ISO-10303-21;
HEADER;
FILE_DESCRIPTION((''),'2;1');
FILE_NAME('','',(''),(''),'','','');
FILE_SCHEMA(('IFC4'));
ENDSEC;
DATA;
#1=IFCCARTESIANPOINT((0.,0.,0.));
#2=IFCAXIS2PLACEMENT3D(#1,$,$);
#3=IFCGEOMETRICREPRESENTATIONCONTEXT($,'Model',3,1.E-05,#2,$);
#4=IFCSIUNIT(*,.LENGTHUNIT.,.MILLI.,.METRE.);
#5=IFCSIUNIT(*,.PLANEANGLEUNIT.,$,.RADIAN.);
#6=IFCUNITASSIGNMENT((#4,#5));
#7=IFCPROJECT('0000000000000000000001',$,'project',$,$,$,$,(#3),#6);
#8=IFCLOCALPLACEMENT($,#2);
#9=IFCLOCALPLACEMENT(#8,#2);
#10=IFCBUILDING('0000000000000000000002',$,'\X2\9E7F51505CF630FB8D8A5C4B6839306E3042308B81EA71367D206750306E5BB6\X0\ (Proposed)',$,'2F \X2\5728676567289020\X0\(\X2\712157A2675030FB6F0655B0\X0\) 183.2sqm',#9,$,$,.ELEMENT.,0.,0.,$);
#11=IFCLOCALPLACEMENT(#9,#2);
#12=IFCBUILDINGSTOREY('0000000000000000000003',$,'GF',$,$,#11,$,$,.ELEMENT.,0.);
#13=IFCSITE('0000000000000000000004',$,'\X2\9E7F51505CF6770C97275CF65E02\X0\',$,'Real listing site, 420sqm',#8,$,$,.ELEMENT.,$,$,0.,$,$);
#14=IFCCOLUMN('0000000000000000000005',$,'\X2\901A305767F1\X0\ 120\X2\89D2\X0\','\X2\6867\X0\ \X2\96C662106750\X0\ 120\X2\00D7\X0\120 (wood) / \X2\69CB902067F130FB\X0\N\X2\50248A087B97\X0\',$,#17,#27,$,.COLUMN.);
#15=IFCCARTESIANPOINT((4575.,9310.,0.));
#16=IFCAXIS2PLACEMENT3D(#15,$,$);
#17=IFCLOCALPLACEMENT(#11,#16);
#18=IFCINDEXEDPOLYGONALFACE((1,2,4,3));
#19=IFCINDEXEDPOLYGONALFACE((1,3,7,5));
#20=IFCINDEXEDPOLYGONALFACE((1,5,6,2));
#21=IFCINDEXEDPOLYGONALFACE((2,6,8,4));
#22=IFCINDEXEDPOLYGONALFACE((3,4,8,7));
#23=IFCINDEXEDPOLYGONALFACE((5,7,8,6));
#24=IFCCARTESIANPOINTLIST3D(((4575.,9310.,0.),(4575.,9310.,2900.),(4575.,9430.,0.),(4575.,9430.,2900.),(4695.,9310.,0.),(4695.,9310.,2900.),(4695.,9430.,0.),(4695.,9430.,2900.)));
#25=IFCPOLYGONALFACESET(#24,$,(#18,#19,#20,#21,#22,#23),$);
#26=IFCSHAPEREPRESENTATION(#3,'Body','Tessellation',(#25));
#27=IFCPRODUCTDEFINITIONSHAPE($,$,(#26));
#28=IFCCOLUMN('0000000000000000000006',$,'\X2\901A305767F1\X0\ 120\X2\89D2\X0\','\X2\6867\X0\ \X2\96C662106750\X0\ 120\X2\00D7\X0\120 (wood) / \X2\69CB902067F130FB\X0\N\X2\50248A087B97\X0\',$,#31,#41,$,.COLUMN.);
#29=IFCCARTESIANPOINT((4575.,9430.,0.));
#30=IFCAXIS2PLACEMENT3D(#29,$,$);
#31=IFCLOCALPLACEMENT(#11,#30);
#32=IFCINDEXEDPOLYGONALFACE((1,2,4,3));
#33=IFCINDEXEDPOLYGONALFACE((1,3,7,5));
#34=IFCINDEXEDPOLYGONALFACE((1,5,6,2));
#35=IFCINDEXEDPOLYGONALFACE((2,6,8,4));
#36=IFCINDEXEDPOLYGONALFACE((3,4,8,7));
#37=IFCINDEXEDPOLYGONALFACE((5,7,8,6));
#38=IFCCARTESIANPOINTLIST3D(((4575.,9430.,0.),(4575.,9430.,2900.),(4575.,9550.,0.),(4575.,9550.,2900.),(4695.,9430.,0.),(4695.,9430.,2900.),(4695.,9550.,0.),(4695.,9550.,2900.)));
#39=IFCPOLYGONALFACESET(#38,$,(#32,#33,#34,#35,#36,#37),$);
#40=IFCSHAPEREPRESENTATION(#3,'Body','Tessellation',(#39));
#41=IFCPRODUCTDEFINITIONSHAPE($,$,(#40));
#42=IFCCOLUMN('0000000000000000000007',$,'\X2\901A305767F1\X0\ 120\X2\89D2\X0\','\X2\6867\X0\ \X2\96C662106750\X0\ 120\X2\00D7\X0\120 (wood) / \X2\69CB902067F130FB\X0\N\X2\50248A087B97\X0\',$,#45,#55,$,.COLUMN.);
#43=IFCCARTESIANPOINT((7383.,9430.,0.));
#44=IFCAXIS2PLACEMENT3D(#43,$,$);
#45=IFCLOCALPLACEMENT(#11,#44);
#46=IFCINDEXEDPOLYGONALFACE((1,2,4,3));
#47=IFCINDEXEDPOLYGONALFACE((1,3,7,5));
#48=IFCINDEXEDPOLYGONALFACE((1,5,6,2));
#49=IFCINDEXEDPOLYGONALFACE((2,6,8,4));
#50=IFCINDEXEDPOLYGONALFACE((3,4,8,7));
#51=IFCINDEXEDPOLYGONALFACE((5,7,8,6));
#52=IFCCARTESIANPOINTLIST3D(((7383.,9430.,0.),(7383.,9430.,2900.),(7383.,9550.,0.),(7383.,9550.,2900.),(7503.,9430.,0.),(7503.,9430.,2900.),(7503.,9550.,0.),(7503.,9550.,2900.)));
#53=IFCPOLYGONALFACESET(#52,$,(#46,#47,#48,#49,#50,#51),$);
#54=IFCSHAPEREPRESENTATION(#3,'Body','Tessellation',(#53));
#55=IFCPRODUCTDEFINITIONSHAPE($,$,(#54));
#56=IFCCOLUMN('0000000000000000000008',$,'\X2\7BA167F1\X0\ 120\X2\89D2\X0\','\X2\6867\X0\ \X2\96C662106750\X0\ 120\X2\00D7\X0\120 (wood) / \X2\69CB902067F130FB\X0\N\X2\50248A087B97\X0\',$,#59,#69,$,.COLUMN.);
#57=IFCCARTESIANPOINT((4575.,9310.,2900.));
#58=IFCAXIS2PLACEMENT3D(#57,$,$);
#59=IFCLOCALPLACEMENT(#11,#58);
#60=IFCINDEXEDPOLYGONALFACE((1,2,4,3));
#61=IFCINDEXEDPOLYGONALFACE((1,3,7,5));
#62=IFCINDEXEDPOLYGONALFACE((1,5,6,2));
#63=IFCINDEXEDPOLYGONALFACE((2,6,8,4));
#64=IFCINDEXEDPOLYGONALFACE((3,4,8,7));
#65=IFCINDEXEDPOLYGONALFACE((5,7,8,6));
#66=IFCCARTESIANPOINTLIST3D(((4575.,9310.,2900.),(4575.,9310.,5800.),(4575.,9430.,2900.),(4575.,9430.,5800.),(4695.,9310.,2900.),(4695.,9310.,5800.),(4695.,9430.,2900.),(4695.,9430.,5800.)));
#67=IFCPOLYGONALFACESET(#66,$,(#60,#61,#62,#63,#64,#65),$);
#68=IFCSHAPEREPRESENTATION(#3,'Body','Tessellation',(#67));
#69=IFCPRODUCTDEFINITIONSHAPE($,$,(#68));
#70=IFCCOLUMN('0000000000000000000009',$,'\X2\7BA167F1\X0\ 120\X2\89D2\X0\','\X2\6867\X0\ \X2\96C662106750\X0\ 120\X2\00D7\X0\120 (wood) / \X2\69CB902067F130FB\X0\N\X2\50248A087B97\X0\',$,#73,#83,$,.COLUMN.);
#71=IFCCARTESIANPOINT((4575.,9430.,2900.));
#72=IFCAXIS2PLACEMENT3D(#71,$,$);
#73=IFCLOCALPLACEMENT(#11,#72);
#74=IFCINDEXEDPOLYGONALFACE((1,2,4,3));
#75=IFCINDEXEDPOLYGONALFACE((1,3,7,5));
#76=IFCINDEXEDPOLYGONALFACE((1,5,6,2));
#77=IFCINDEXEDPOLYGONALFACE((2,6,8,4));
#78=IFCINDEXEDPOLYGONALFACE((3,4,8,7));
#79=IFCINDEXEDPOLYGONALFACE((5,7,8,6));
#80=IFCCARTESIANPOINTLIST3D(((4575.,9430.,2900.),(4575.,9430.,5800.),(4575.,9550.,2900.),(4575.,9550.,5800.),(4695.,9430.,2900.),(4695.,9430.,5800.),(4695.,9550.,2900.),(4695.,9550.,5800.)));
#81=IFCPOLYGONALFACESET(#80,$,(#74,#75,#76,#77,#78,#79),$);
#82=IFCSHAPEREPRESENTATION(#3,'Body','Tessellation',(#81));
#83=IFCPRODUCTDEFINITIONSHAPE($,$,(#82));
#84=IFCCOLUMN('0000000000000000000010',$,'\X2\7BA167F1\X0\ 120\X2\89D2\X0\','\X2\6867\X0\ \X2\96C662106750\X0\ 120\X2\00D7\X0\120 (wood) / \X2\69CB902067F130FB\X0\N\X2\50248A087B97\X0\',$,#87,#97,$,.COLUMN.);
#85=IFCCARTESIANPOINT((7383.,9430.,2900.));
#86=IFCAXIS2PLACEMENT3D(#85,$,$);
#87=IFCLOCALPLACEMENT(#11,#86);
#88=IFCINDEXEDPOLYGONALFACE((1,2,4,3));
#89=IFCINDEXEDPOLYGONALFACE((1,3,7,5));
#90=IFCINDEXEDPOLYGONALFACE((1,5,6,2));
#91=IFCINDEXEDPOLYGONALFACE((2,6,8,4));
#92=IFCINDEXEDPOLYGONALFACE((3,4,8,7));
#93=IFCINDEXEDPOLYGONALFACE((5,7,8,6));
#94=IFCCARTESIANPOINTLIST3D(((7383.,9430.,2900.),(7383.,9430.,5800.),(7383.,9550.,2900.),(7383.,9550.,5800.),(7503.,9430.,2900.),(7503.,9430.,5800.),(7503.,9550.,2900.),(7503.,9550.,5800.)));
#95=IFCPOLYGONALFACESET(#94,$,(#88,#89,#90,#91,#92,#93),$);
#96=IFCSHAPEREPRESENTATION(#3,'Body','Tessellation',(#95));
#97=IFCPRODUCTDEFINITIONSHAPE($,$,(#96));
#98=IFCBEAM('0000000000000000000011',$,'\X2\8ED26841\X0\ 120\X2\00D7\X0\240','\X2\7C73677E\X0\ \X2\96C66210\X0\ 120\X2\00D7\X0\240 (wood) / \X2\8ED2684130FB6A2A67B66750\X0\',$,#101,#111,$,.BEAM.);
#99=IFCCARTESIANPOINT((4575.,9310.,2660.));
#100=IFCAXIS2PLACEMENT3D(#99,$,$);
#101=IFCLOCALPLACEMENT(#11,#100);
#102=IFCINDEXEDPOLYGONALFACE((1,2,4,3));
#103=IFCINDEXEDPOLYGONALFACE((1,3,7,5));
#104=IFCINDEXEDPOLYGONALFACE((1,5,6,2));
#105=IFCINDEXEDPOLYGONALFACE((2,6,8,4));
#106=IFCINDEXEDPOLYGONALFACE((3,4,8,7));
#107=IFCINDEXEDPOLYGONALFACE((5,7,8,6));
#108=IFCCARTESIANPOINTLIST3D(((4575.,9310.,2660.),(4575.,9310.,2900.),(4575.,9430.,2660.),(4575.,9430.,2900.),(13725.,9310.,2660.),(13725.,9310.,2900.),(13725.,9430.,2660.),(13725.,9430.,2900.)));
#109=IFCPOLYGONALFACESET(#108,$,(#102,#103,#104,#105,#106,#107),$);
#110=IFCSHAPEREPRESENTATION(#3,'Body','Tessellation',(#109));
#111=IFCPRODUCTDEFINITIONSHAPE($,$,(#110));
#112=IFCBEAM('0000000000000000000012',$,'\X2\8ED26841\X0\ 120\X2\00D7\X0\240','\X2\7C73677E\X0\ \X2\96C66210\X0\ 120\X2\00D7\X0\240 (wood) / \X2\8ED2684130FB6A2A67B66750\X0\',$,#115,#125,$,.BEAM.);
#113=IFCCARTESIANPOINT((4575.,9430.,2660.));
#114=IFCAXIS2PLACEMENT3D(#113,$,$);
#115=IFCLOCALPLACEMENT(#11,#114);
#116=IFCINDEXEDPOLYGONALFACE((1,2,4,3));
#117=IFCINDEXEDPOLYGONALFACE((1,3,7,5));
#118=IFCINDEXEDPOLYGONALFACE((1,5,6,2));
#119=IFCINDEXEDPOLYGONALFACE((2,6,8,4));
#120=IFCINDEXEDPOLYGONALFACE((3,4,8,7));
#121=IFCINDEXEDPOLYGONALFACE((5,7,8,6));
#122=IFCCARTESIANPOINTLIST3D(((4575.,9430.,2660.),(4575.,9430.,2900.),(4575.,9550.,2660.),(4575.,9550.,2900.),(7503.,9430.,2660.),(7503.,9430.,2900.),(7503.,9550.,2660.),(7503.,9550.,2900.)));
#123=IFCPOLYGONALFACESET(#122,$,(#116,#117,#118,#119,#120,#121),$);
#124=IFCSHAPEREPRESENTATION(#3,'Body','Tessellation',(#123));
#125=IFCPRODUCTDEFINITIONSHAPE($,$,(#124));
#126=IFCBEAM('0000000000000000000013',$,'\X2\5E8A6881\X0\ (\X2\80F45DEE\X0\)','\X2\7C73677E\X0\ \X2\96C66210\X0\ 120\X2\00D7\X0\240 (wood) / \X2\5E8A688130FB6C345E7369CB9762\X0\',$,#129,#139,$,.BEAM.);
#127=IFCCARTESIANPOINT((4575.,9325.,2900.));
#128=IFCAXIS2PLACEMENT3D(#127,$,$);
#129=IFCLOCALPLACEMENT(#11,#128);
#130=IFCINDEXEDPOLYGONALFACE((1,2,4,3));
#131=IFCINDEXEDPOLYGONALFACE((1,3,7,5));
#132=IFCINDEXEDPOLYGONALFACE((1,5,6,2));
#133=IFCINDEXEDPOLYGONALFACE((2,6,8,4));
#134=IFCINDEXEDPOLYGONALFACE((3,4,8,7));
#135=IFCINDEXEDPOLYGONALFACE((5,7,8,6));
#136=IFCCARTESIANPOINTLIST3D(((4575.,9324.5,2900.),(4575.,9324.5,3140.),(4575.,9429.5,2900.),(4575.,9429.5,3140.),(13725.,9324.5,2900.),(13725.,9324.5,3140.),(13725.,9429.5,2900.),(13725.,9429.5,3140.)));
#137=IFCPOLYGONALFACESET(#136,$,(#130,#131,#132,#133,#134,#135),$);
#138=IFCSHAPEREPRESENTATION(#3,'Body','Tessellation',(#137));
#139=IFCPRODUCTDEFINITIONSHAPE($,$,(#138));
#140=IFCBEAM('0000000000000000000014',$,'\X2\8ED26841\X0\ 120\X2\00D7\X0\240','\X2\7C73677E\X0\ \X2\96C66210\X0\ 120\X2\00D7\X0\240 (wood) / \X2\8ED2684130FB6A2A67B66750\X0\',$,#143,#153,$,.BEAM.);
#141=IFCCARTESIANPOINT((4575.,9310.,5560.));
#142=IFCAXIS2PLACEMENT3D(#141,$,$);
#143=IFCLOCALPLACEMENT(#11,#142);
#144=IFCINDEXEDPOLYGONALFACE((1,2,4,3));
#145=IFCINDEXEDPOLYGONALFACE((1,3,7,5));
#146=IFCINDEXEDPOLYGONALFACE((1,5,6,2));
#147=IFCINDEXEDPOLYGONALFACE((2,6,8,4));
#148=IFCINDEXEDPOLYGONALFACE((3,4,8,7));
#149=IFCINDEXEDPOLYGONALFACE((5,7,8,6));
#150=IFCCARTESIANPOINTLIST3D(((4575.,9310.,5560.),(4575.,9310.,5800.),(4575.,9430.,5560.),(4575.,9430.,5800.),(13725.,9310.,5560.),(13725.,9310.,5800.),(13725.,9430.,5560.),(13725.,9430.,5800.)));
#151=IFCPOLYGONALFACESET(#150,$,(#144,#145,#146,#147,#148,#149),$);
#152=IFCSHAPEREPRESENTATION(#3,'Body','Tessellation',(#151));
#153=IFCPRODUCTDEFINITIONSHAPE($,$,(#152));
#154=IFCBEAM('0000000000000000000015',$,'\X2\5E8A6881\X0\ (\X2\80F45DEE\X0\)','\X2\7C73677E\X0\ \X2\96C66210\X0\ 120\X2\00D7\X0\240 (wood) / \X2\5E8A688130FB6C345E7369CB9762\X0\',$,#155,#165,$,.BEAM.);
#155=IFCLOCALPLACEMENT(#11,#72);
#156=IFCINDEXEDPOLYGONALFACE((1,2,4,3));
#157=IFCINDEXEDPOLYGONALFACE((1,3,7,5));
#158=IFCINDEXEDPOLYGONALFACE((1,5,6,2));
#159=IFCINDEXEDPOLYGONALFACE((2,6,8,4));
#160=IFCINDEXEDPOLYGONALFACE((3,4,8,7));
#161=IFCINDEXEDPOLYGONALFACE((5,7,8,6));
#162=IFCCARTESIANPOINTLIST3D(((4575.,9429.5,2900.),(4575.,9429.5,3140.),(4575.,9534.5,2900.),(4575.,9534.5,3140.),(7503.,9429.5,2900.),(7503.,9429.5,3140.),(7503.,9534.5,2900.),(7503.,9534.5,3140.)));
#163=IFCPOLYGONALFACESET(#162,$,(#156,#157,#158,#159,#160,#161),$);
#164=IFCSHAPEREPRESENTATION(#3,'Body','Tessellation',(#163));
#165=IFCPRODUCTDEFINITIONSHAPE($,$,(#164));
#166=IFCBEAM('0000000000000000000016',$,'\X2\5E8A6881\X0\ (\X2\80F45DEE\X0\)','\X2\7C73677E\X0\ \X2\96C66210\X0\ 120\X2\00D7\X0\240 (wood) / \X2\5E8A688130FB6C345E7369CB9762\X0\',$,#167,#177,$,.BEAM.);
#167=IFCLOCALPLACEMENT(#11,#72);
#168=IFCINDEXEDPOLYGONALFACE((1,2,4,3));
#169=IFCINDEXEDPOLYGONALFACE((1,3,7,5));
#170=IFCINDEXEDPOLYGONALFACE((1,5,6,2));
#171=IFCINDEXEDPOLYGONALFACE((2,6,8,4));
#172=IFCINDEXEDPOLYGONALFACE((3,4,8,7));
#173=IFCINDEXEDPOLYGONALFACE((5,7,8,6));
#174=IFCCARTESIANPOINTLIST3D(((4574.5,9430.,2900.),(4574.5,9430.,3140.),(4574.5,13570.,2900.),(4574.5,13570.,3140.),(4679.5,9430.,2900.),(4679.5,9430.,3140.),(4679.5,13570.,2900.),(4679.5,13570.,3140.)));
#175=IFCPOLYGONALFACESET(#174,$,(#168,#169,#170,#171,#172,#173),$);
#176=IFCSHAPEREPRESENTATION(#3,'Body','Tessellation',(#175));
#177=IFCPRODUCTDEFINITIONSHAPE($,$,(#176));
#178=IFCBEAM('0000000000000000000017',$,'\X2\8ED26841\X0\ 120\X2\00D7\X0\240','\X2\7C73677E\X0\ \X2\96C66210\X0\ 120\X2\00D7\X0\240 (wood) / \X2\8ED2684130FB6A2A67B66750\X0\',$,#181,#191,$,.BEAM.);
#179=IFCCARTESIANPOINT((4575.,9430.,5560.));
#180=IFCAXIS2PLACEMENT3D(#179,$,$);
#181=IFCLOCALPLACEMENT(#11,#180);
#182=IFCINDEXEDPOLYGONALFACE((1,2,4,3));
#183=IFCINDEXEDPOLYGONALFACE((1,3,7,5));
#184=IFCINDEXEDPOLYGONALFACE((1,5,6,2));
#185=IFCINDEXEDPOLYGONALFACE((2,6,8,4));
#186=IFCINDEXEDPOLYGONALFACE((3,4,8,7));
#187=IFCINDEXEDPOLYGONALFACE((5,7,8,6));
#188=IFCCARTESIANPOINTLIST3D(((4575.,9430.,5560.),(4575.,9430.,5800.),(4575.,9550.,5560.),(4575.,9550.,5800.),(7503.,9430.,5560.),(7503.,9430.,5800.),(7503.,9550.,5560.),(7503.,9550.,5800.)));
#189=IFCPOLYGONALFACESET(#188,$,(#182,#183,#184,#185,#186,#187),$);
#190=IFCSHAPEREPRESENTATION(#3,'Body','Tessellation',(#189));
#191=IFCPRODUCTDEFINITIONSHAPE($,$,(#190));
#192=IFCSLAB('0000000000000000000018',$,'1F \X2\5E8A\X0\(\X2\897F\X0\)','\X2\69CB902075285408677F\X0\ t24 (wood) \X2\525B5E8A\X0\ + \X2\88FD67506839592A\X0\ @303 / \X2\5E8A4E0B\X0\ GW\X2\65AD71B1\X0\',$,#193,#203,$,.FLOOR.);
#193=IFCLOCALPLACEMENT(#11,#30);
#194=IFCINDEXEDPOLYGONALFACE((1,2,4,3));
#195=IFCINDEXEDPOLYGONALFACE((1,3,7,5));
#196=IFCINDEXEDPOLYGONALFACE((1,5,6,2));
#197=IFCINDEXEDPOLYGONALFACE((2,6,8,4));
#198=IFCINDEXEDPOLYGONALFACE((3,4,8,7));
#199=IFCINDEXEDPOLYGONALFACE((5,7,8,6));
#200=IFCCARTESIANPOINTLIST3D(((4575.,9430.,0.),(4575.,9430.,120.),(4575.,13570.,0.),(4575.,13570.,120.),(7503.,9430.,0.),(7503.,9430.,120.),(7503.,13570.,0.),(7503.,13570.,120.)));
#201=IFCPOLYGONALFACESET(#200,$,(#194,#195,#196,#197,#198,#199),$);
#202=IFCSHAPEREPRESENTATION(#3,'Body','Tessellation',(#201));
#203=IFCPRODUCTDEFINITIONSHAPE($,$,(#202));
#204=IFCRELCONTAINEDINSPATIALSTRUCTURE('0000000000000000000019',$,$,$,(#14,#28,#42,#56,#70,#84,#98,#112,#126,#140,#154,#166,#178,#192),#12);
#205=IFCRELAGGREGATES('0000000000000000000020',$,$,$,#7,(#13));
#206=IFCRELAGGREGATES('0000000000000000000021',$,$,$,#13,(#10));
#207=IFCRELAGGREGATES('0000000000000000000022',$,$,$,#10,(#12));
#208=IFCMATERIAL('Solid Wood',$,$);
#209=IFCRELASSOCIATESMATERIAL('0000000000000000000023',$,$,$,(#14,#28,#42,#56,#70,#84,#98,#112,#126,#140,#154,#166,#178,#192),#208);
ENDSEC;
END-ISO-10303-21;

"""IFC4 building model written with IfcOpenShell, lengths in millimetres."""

from ifc_helpers import new_model, si_unit, frame, frame_2d, origin, place, context, project, spatial, rectangle, extrude, material, element, save


model = new_model("IFC4")

# Units and contexts
model_context = context("Model", 3, precision=1e-05, world=origin())
ifc_project = project(units=[si_unit("LENGTHUNIT", "METRE", prefix="MILLI"), si_unit("PLANEANGLEUNIT", "RADIAN")], contexts=[model_context])

# Site, building, storey
site_placement = place(None, origin())
site = spatial("IfcSite", under=ifc_project, at=site_placement, Name="鹿児島県霧島市", ObjectType="Real listing site, 420sqm", CompositionType="ELEMENT", RefElevation=0.0)
building_placement = place(site_placement, origin())
building = spatial("IfcBuilding", under=site, at=building_placement, Name="鹿児島・越屋根のある自然素材の家 (Proposed)", ObjectType="2F 在来木造(無垢材・漆喰) 183.2sqm", CompositionType="ELEMENT", ElevationOfRefHeight=0.0, ElevationOfTerrain=0.0)
storey_placement = place(building_placement, origin())
storey = spatial("IfcBuildingStorey", under=building, at=storey_placement, Name="GF", CompositionType="ELEMENT", Elevation=0.0)

# Columns
ifc_material_1 = material(Name="Solid Wood")
column_1_placement = place(storey_placement, frame((4575.0, 9310.0, 0.0)))
element("IfcColumn", 1, at=column_1_placement, inside=storey, material=ifc_material_1, Name="通し柱 120角", Description="桧 集成材 120×120 (wood) / 構造柱・N値計算", PredefinedType="COLUMN", context=model_context, shape_type="SweptSolid", body=[
    extrude(rectangle(XDim=120.0, YDim=120.0, at=frame_2d((60.0, 60.0))), frame((4575.0, 9310.0, 0.0)), (0.0, 0.0, 1.0), 2900.0),
])
column_2_placement = place(storey_placement, frame((4575.0, 9430.0, 0.0)))
element("IfcColumn", 2, at=column_2_placement, inside=storey, material=ifc_material_1, Name="通し柱 120角", Description="桧 集成材 120×120 (wood) / 構造柱・N値計算", PredefinedType="COLUMN", context=model_context, shape_type="SweptSolid", body=[
    extrude(rectangle(XDim=120.0, YDim=120.0, at=frame_2d((60.0, 60.0))), frame((4575.0, 9430.0, 0.0)), (0.0, 0.0, 1.0), 2900.0),
])
column_3_placement = place(storey_placement, frame((7383.0, 9430.0, 0.0)))
element("IfcColumn", 3, at=column_3_placement, inside=storey, material=ifc_material_1, Name="通し柱 120角", Description="桧 集成材 120×120 (wood) / 構造柱・N値計算", PredefinedType="COLUMN", context=model_context, shape_type="SweptSolid", body=[
    extrude(rectangle(XDim=120.0, YDim=120.0, at=frame_2d((60.0, 60.0))), frame((7383.0, 9430.0, 0.0)), (0.0, 0.0, 1.0), 2900.0),
])
column_4_placement = place(storey_placement, frame((4575.0, 9310.0, 2900.0)))
element("IfcColumn", 4, at=column_4_placement, inside=storey, material=ifc_material_1, Name="管柱 120角", Description="桧 集成材 120×120 (wood) / 構造柱・N値計算", PredefinedType="COLUMN", context=model_context, shape_type="SweptSolid", body=[
    extrude(rectangle(XDim=120.0, YDim=120.0, at=frame_2d((60.0, 60.0))), frame((4575.0, 9310.0, 2900.0)), (0.0, 0.0, 1.0), 2900.0),
])
column_5_placement = place(storey_placement, frame((4575.0, 9430.0, 2900.0)))
element("IfcColumn", 5, at=column_5_placement, inside=storey, material=ifc_material_1, Name="管柱 120角", Description="桧 集成材 120×120 (wood) / 構造柱・N値計算", PredefinedType="COLUMN", context=model_context, shape_type="SweptSolid", body=[
    extrude(rectangle(XDim=120.0, YDim=120.0, at=frame_2d((60.0, 60.0))), frame((4575.0, 9430.0, 2900.0)), (0.0, 0.0, 1.0), 2900.0),
])
column_6_placement = place(storey_placement, frame((7383.0, 9430.0, 2900.0)))
element("IfcColumn", 6, at=column_6_placement, inside=storey, material=ifc_material_1, Name="管柱 120角", Description="桧 集成材 120×120 (wood) / 構造柱・N値計算", PredefinedType="COLUMN", context=model_context, shape_type="SweptSolid", body=[
    extrude(rectangle(XDim=120.0, YDim=120.0, at=frame_2d((60.0, 60.0))), frame((7383.0, 9430.0, 2900.0)), (0.0, 0.0, 1.0), 2900.0),
])

# Beams
beam_1_placement = place(storey_placement, frame((4575.0, 9310.0, 2660.0)))
element("IfcBeam", 7, at=beam_1_placement, inside=storey, material=ifc_material_1, Name="軒桁 120×240", Description="米松 集成 120×240 (wood) / 軒桁・横架材", PredefinedType="BEAM", context=model_context, shape_type="SweptSolid", body=[
    extrude(rectangle(XDim=9150.0, YDim=120.0, at=frame_2d((4575.0, 60.0))), frame((4575.0, 9310.0, 2660.0)), (0.0, 0.0, 1.0), 240.0),
])
beam_2_placement = place(storey_placement, frame((4575.0, 9430.0, 2660.0)))
element("IfcBeam", 8, at=beam_2_placement, inside=storey, material=ifc_material_1, Name="軒桁 120×240", Description="米松 集成 120×240 (wood) / 軒桁・横架材", PredefinedType="BEAM", context=model_context, shape_type="SweptSolid", body=[
    extrude(rectangle(XDim=2928.0, YDim=120.0, at=frame_2d((1464.0, 60.0))), frame((4575.0, 9430.0, 2660.0)), (0.0, 0.0, 1.0), 240.0),
])
beam_3_placement = place(storey_placement, frame((4575.0, 9325.0, 2900.0)))
element("IfcBeam", 9, at=beam_3_placement, inside=storey, material=ifc_material_1, Name="床梁 (胴差)", Description="米松 集成 120×240 (wood) / 床梁・水平構面", PredefinedType="BEAM", context=model_context, shape_type="SweptSolid", body=[
    extrude(rectangle(XDim=9150.0, YDim=105.0, at=frame_2d((4575.0, 52.0))), frame((4575.0, 9325.0, 2900.0)), (0.0, 0.0, 1.0), 240.0),
])
beam_4_placement = place(storey_placement, frame((4575.0, 9310.0, 5560.0)))
element("IfcBeam", 10, at=beam_4_placement, inside=storey, material=ifc_material_1, Name="軒桁 120×240", Description="米松 集成 120×240 (wood) / 軒桁・横架材", PredefinedType="BEAM", context=model_context, shape_type="SweptSolid", body=[
    extrude(rectangle(XDim=9150.0, YDim=120.0, at=frame_2d((4575.0, 60.0))), frame((4575.0, 9310.0, 5560.0)), (0.0, 0.0, 1.0), 240.0),
])
beam_5_placement = place(storey_placement, frame((4575.0, 9430.0, 2900.0)))
element("IfcBeam", 11, at=beam_5_placement, inside=storey, material=ifc_material_1, Name="床梁 (胴差)", Description="米松 集成 120×240 (wood) / 床梁・水平構面", PredefinedType="BEAM", context=model_context, shape_type="SweptSolid", body=[
    extrude(rectangle(XDim=2928.0, YDim=105.0, at=frame_2d((1464.0, 52.0))), frame((4575.0, 9430.0, 2900.0)), (0.0, 0.0, 1.0), 240.0),
])
beam_6_placement = place(storey_placement, frame((4575.0, 9430.0, 2900.0)))
element("IfcBeam", 12, at=beam_6_placement, inside=storey, material=ifc_material_1, Name="床梁 (胴差)", Description="米松 集成 120×240 (wood) / 床梁・水平構面", PredefinedType="BEAM", context=model_context, shape_type="SweptSolid", body=[
    extrude(rectangle(XDim=105.0, YDim=4140.0, at=frame_2d((52.0, 2070.0))), frame((4575.0, 9430.0, 2900.0)), (0.0, 0.0, 1.0), 240.0),
])
beam_7_placement = place(storey_placement, frame((4575.0, 9430.0, 5560.0)))
element("IfcBeam", 13, at=beam_7_placement, inside=storey, material=ifc_material_1, Name="軒桁 120×240", Description="米松 集成 120×240 (wood) / 軒桁・横架材", PredefinedType="BEAM", context=model_context, shape_type="SweptSolid", body=[
    extrude(rectangle(XDim=2928.0, YDim=120.0, at=frame_2d((1464.0, 60.0))), frame((4575.0, 9430.0, 5560.0)), (0.0, 0.0, 1.0), 240.0),
])

# Slab
slab_1_placement = place(storey_placement, frame((4575.0, 9430.0, 0.0)))
element("IfcSlab", 14, at=slab_1_placement, inside=storey, material=ifc_material_1, Name="1F 床(西)", Description="構造用合板 t24 (wood) 剛床 + 製材根太 @303 / 床下 GW断熱", PredefinedType="FLOOR", context=model_context, shape_type="SweptSolid", body=[
    extrude(rectangle(XDim=2928.0, YDim=4140.0, at=frame_2d((1464.0, 2070.0))), frame((4575.0, 9430.0, 0.0)), (0.0, 0.0, 1.0), 120.0),
])

save(model, "model.ifc")
